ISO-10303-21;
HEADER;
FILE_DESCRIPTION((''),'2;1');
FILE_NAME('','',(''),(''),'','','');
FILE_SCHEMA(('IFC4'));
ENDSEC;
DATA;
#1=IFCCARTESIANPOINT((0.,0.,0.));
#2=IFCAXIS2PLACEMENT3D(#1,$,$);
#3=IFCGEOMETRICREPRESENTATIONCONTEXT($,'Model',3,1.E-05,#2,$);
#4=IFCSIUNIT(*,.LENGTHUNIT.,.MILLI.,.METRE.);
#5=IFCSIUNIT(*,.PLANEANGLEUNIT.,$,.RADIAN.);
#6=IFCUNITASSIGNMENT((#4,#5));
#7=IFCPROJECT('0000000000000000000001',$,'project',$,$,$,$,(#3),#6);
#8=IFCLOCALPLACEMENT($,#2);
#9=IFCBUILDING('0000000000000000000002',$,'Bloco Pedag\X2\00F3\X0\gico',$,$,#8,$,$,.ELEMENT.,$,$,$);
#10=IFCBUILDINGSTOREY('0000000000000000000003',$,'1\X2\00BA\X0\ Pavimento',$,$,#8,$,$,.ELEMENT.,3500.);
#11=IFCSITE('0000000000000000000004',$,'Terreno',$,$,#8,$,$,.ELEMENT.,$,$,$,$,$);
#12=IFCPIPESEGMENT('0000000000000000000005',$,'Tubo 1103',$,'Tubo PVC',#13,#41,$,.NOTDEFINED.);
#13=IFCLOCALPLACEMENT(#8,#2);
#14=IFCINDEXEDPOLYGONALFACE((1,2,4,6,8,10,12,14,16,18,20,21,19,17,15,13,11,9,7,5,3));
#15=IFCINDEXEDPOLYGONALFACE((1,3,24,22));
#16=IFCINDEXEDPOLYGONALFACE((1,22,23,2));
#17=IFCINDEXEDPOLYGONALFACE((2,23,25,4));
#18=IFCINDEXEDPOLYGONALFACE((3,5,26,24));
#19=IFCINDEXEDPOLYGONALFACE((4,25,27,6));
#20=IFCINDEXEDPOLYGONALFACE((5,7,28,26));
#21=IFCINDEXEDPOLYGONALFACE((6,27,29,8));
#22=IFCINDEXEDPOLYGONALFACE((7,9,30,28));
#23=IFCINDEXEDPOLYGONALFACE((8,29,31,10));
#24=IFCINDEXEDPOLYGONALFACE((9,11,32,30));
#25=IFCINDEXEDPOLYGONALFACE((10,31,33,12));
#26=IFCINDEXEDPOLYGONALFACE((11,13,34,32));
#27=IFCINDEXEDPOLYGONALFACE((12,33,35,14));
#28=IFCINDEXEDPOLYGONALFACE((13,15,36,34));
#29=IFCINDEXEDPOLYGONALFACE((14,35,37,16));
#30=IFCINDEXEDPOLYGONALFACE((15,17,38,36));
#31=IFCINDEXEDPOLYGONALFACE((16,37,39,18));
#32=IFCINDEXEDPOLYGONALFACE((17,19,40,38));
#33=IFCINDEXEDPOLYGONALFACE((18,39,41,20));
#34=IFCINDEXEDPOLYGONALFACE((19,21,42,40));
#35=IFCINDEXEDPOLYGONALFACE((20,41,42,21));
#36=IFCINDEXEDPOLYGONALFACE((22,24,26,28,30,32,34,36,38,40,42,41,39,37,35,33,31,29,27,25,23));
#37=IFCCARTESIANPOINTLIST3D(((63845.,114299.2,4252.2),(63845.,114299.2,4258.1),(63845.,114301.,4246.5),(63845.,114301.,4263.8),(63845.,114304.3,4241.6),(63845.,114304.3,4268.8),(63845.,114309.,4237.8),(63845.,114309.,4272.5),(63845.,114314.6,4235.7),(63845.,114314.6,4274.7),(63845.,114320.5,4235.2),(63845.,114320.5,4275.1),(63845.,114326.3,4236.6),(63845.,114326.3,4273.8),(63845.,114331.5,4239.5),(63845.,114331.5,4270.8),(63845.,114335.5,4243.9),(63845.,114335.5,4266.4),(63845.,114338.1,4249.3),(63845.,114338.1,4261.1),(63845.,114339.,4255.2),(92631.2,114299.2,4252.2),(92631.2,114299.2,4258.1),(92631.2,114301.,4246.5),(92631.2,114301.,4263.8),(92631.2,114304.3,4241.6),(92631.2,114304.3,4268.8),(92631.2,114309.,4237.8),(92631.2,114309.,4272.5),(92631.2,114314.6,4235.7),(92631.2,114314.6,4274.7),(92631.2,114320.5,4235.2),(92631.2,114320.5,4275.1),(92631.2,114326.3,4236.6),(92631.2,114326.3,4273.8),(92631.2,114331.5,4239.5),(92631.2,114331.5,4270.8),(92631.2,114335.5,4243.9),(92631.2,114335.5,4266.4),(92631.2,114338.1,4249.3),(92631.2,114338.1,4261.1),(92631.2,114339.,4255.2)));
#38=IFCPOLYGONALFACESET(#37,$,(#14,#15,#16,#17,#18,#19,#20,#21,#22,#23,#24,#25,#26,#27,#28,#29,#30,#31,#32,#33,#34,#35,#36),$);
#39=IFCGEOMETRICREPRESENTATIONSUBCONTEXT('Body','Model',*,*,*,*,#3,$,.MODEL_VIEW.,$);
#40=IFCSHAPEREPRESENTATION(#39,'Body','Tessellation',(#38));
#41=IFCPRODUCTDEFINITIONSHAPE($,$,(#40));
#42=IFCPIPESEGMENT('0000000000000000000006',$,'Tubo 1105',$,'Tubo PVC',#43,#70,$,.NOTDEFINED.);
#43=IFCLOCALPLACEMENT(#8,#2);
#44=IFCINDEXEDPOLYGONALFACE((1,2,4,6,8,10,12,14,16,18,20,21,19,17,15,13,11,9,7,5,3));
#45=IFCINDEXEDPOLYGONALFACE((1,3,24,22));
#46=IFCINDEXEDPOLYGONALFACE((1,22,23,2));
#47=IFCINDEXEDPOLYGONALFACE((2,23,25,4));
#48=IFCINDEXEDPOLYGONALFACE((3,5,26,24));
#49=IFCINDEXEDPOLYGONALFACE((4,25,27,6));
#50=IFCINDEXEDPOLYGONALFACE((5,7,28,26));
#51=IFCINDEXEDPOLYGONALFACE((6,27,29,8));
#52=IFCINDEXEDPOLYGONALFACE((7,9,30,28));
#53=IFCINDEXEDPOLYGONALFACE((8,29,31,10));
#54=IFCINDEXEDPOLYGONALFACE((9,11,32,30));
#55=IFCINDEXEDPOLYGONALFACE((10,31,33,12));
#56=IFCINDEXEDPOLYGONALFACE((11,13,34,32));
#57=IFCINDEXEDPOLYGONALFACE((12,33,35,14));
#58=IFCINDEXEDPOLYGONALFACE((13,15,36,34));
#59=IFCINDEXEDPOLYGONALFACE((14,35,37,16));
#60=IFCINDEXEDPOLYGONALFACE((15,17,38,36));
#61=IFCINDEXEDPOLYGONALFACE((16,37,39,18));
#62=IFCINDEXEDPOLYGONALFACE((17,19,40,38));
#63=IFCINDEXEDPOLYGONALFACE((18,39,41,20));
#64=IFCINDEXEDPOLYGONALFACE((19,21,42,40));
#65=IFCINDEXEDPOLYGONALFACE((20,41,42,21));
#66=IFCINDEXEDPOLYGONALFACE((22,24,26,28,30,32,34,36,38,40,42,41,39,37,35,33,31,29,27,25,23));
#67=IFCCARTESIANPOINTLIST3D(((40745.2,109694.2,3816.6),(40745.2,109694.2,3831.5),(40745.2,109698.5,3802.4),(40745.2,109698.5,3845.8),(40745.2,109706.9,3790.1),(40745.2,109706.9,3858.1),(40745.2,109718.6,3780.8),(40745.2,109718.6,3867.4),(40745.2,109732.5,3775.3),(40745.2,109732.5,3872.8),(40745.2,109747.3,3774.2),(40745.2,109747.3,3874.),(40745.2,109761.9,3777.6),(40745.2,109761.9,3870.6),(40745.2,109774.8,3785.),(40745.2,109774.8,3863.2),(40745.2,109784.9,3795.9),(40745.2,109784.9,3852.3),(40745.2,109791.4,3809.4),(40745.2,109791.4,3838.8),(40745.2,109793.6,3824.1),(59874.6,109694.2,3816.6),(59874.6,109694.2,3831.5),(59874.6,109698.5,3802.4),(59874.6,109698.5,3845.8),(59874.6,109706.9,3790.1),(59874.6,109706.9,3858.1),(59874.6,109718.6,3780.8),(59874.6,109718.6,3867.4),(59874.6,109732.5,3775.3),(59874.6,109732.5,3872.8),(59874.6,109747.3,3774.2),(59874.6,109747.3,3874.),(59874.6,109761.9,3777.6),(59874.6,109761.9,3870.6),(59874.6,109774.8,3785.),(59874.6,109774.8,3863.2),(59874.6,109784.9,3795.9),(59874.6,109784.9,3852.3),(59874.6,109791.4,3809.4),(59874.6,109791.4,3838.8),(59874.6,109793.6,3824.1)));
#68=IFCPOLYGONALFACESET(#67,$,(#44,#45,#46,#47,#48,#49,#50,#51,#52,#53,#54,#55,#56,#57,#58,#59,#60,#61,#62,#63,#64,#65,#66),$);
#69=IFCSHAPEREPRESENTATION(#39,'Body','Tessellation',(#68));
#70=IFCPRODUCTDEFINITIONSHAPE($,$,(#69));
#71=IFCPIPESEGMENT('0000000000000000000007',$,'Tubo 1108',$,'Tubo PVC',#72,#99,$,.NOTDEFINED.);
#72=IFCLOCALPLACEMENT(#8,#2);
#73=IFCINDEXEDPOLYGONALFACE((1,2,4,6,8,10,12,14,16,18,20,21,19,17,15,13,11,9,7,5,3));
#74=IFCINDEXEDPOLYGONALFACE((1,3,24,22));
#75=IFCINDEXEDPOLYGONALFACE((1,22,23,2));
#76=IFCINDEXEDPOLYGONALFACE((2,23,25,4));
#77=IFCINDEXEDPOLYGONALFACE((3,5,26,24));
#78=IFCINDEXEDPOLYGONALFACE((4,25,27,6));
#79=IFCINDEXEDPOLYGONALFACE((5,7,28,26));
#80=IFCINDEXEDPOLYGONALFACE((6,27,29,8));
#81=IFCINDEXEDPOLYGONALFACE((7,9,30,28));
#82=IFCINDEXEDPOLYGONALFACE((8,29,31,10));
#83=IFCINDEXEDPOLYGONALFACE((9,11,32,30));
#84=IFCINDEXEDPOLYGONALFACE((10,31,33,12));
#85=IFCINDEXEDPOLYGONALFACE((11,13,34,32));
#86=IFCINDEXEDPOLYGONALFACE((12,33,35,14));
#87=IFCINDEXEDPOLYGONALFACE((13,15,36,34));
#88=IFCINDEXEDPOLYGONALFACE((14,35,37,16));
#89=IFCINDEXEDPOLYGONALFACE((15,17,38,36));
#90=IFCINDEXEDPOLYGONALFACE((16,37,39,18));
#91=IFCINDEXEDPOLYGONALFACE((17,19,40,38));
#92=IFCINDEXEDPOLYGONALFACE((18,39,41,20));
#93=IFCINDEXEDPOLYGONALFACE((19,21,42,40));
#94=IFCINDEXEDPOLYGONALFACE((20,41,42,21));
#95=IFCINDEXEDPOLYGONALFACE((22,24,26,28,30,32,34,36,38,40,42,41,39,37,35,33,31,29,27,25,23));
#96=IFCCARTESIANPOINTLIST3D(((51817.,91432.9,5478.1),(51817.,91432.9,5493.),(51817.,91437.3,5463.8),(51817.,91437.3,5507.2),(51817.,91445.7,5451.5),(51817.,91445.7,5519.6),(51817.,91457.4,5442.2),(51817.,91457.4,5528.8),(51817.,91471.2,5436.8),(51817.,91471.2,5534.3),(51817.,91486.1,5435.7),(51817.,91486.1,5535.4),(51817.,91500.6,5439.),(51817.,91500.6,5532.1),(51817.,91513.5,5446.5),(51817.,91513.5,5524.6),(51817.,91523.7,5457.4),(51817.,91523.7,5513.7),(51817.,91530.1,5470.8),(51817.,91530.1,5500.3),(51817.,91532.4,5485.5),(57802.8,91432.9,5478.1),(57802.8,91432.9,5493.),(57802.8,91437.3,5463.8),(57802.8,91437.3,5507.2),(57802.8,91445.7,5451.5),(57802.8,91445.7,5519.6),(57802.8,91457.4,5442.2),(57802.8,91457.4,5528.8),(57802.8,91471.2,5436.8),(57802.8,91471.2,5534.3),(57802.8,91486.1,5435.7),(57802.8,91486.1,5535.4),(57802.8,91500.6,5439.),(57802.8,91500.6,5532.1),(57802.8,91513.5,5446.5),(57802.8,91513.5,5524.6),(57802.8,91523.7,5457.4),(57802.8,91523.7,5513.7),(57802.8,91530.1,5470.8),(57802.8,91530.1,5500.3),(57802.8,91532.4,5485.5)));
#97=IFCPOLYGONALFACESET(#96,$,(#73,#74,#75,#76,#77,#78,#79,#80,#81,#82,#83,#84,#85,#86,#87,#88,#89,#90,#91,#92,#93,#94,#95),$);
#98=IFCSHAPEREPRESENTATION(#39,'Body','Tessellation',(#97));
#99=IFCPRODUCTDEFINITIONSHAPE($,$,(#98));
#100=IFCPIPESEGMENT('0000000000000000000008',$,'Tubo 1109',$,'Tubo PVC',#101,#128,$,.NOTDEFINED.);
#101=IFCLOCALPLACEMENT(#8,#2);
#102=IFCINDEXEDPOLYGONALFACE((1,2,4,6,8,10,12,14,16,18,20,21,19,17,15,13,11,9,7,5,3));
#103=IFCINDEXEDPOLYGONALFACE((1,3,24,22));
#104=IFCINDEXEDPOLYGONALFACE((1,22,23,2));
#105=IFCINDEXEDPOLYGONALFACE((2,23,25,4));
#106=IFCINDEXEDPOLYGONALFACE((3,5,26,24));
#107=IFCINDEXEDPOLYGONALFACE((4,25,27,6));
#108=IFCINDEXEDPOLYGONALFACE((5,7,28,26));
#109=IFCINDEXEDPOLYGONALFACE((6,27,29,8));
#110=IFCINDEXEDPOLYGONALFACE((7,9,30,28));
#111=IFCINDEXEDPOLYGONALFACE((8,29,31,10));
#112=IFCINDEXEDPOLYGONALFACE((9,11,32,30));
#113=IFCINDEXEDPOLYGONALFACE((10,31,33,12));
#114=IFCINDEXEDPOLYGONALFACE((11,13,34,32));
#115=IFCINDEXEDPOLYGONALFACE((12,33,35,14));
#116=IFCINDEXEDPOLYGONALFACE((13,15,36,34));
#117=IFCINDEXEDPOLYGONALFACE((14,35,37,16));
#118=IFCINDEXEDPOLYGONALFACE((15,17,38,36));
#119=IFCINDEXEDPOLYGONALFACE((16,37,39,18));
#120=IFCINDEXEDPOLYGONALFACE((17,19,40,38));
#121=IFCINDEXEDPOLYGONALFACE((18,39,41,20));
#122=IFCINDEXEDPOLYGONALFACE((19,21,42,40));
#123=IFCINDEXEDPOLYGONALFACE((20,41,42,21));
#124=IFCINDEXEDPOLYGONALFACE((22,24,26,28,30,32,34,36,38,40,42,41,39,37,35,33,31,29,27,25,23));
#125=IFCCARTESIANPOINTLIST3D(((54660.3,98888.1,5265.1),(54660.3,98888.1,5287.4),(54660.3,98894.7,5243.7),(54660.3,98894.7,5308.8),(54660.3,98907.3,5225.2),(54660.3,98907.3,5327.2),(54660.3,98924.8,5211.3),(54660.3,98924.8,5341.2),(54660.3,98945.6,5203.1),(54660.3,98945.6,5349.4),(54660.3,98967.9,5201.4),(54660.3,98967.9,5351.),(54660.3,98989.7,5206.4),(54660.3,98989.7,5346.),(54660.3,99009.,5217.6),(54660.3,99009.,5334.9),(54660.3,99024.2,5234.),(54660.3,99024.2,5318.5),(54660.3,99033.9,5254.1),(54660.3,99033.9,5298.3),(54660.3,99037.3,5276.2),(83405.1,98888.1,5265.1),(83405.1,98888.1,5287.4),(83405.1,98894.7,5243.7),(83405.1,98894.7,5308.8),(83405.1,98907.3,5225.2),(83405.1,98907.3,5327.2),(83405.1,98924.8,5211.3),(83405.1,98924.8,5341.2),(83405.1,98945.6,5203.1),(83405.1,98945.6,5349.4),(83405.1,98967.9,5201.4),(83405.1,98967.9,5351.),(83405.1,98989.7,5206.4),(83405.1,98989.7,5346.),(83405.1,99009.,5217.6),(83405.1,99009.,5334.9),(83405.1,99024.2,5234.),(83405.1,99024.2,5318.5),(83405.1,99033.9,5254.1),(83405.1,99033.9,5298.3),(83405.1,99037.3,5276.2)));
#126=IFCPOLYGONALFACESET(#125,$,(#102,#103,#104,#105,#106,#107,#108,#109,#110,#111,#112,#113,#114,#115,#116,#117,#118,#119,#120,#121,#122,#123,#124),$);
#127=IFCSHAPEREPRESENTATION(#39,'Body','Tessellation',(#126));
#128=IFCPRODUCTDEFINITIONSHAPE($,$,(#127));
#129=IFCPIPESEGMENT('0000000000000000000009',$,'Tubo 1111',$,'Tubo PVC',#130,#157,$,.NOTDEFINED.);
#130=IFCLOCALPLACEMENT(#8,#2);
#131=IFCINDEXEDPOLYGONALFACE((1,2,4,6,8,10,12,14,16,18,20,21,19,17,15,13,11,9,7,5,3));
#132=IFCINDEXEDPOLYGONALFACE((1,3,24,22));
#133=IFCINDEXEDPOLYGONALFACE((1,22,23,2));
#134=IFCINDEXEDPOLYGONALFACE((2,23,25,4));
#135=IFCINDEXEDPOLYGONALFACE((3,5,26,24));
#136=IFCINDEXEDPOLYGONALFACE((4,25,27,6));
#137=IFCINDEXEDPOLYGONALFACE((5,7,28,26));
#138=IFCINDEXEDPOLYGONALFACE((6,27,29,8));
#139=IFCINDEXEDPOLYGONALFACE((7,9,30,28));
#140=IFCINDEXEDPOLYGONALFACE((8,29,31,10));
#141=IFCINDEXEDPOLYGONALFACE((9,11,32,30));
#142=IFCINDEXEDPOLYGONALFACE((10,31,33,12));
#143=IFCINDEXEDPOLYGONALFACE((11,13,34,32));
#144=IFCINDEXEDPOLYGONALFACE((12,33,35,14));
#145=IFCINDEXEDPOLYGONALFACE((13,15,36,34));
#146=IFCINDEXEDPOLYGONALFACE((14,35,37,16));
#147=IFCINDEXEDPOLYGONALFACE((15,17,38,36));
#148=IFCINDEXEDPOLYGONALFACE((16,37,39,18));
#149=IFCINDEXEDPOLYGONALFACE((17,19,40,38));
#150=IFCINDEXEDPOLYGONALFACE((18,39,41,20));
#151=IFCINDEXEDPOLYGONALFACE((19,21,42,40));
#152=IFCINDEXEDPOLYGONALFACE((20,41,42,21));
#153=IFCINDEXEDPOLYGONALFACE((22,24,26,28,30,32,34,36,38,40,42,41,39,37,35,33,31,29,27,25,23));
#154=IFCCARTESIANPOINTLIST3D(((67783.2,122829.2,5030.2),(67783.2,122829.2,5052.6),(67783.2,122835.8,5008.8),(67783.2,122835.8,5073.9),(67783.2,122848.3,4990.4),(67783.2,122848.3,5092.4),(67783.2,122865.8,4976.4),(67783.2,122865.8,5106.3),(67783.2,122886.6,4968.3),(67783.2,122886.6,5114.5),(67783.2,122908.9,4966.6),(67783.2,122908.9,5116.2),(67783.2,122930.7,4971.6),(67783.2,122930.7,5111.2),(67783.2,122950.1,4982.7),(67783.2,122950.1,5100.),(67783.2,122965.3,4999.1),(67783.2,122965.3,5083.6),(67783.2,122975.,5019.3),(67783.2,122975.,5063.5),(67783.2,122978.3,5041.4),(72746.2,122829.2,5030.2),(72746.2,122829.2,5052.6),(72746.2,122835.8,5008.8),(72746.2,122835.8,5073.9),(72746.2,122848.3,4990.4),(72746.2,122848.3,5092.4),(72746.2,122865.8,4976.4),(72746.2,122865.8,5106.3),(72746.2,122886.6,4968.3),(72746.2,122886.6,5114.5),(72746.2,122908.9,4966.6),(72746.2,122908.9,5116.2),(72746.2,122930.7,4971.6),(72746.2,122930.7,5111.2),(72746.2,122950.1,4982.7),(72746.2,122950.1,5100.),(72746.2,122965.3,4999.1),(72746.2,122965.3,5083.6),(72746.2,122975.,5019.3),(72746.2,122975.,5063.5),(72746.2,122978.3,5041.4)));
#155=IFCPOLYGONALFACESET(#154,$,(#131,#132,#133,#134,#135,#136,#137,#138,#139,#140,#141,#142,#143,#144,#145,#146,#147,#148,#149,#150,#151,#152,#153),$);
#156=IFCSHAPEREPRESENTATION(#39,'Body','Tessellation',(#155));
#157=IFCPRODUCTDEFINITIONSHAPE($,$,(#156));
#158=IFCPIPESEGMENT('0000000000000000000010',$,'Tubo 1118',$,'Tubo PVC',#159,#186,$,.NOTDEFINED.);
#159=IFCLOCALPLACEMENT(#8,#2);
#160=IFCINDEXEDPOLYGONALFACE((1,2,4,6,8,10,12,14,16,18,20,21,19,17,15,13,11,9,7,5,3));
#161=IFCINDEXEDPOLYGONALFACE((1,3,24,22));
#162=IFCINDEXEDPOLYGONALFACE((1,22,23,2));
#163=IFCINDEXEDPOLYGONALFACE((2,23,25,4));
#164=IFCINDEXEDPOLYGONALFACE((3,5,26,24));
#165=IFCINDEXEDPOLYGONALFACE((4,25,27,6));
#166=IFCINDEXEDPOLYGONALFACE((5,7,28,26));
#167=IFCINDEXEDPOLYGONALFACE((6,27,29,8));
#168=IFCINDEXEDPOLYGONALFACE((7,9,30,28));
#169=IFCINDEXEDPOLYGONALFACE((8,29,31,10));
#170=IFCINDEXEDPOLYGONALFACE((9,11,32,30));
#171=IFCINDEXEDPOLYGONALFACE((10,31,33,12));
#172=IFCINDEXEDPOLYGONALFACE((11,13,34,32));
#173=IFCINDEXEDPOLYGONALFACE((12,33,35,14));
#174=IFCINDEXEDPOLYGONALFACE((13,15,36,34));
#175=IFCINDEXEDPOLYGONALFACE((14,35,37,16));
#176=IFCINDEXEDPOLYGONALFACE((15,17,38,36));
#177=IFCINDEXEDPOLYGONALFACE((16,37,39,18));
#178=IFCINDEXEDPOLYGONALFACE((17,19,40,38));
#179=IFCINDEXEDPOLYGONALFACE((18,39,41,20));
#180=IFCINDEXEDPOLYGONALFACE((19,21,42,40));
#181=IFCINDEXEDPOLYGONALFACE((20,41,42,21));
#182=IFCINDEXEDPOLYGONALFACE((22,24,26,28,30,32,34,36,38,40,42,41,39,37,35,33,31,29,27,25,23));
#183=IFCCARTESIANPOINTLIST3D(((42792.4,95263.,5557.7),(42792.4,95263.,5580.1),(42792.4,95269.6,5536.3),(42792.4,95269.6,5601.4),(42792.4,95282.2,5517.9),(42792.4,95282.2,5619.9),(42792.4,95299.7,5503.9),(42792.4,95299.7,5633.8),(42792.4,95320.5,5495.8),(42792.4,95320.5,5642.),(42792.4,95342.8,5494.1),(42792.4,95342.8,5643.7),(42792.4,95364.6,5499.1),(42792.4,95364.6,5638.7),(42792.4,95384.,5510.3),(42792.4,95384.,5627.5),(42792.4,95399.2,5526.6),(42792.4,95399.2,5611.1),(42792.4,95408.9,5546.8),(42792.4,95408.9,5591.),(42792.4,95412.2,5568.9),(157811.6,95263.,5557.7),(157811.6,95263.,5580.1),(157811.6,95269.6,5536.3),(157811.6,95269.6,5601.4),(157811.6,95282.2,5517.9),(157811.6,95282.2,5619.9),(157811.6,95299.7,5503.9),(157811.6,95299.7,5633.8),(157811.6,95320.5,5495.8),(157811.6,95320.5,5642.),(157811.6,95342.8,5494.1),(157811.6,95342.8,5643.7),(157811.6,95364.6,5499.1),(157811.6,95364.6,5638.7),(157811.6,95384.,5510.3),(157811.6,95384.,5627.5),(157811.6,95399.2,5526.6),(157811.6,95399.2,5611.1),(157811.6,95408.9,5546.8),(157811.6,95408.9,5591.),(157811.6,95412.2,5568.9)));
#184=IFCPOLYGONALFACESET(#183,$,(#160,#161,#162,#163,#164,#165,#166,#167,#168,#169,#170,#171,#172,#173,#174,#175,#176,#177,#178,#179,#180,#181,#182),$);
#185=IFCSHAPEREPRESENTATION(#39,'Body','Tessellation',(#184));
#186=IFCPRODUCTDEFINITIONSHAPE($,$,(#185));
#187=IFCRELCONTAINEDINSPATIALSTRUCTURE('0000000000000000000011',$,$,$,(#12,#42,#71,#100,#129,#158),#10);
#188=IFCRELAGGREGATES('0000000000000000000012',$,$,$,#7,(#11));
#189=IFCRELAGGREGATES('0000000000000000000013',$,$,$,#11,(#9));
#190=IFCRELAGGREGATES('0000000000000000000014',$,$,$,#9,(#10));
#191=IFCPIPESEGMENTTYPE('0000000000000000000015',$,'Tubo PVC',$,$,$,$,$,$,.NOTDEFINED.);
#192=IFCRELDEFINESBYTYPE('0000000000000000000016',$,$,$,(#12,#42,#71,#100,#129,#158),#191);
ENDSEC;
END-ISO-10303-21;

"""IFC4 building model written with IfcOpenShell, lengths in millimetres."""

from ifc_helpers import new_model, si_unit, frame, origin, origin_2d, place, context, subcontext, project, spatial, circle, extrude, type_object, element, save


model = new_model("IFC4")

# Units and contexts
model_context = context("Model", 3, precision=1e-05, world=origin())
body_context = subcontext(model_context, "Body", "Model", "MODEL_VIEW")
ifc_project = project(units=[si_unit("LENGTHUNIT", "METRE", prefix="MILLI"), si_unit("PLANEANGLEUNIT", "RADIAN")], contexts=[model_context])

# Site, building, storey
placement = place(None, origin())
site = spatial("IfcSite", under=ifc_project, at=placement, Name="Terreno", CompositionType="ELEMENT")
building = spatial("IfcBuilding", under=site, at=placement, Name="Bloco Pedagógico", CompositionType="ELEMENT")
storey = spatial("IfcBuildingStorey", under=building, at=placement, Name="1º Pavimento", CompositionType="ELEMENT", Elevation=3500.0)

# Pipe segments
pipe_segment_type = type_object("IfcPipeSegmentType", Name="Tubo PVC", PredefinedType="NOTDEFINED")
pipe_segment_1_placement = place(None, frame((63845.0, 114319.0, 4255.2), z_axis=(1.0, 0.0, 0.0), x_axis=(0.0, 1.0, 0.0)))
element("IfcPipeSegment", 1, at=pipe_segment_1_placement, inside=storey, type_object=pipe_segment_type, Name="Tubo 1103", ObjectType="Tubo PVC", PredefinedType="NOTDEFINED", context=body_context, shape_type="SweptSolid", body=[
    extrude(circle(Radius=20.0, at=origin_2d()), None, (0.0, 0.0, 1.0), 28786.2),
])
pipe_segment_2_placement = place(None, frame((40745.2, 109743.6, 3824.1), z_axis=(1.0, 0.0, 0.0), x_axis=(0.0, 1.0, 0.0)))
element("IfcPipeSegment", 2, at=pipe_segment_2_placement, inside=storey, type_object=pipe_segment_type, Name="Tubo 1105", ObjectType="Tubo PVC", PredefinedType="NOTDEFINED", context=body_context, shape_type="SweptSolid", body=[
    extrude(circle(Radius=50.0, at=origin_2d()), None, (0.0, 0.0, 1.0), 19129.4),
])
pipe_segment_3_placement = place(None, frame((51817.0, 91482.4, 5485.5), z_axis=(1.0, 0.0, 0.0), x_axis=(0.0, 1.0, 0.0)))
element("IfcPipeSegment", 3, at=pipe_segment_3_placement, inside=storey, type_object=pipe_segment_type, Name="Tubo 1108", ObjectType="Tubo PVC", PredefinedType="NOTDEFINED", context=body_context, shape_type="SweptSolid", body=[
    extrude(circle(Radius=50.0, at=origin_2d()), None, (0.0, 0.0, 1.0), 5985.9),
])
pipe_segment_4_placement = place(None, frame((54660.3, 98962.3, 5276.2), z_axis=(1.0, 0.0, 0.0), x_axis=(0.0, 1.0, 0.0)))
element("IfcPipeSegment", 4, at=pipe_segment_4_placement, inside=storey, type_object=pipe_segment_type, Name="Tubo 1109", ObjectType="Tubo PVC", PredefinedType="NOTDEFINED", context=body_context, shape_type="SweptSolid", body=[
    extrude(circle(Radius=75.0, at=origin_2d()), None, (0.0, 0.0, 1.0), 28744.8),
])
pipe_segment_5_placement = place(None, frame((67783.2, 122903.3, 5041.4), z_axis=(1.0, 0.0, 0.0), x_axis=(0.0, 1.0, 0.0)))
element("IfcPipeSegment", 5, at=pipe_segment_5_placement, inside=storey, type_object=pipe_segment_type, Name="Tubo 1111", ObjectType="Tubo PVC", PredefinedType="NOTDEFINED", context=body_context, shape_type="SweptSolid", body=[
    extrude(circle(Radius=75.0, at=origin_2d()), None, (0.0, 0.0, 1.0), 4963.0),
])
pipe_segment_6_placement = place(None, frame((42792.4, 95337.2, 5568.9), z_axis=(1.0, 0.0, 0.0), x_axis=(0.0, 1.0, 0.0)))
element("IfcPipeSegment", 6, at=pipe_segment_6_placement, inside=storey, type_object=pipe_segment_type, Name="Tubo 1118", ObjectType="Tubo PVC", PredefinedType="NOTDEFINED", context=body_context, shape_type="SweptSolid", body=[
    extrude(circle(Radius=75.0, at=origin_2d()), None, (0.0, 0.0, 1.0), 115019.3),
])

save(model, "model.ifc")
